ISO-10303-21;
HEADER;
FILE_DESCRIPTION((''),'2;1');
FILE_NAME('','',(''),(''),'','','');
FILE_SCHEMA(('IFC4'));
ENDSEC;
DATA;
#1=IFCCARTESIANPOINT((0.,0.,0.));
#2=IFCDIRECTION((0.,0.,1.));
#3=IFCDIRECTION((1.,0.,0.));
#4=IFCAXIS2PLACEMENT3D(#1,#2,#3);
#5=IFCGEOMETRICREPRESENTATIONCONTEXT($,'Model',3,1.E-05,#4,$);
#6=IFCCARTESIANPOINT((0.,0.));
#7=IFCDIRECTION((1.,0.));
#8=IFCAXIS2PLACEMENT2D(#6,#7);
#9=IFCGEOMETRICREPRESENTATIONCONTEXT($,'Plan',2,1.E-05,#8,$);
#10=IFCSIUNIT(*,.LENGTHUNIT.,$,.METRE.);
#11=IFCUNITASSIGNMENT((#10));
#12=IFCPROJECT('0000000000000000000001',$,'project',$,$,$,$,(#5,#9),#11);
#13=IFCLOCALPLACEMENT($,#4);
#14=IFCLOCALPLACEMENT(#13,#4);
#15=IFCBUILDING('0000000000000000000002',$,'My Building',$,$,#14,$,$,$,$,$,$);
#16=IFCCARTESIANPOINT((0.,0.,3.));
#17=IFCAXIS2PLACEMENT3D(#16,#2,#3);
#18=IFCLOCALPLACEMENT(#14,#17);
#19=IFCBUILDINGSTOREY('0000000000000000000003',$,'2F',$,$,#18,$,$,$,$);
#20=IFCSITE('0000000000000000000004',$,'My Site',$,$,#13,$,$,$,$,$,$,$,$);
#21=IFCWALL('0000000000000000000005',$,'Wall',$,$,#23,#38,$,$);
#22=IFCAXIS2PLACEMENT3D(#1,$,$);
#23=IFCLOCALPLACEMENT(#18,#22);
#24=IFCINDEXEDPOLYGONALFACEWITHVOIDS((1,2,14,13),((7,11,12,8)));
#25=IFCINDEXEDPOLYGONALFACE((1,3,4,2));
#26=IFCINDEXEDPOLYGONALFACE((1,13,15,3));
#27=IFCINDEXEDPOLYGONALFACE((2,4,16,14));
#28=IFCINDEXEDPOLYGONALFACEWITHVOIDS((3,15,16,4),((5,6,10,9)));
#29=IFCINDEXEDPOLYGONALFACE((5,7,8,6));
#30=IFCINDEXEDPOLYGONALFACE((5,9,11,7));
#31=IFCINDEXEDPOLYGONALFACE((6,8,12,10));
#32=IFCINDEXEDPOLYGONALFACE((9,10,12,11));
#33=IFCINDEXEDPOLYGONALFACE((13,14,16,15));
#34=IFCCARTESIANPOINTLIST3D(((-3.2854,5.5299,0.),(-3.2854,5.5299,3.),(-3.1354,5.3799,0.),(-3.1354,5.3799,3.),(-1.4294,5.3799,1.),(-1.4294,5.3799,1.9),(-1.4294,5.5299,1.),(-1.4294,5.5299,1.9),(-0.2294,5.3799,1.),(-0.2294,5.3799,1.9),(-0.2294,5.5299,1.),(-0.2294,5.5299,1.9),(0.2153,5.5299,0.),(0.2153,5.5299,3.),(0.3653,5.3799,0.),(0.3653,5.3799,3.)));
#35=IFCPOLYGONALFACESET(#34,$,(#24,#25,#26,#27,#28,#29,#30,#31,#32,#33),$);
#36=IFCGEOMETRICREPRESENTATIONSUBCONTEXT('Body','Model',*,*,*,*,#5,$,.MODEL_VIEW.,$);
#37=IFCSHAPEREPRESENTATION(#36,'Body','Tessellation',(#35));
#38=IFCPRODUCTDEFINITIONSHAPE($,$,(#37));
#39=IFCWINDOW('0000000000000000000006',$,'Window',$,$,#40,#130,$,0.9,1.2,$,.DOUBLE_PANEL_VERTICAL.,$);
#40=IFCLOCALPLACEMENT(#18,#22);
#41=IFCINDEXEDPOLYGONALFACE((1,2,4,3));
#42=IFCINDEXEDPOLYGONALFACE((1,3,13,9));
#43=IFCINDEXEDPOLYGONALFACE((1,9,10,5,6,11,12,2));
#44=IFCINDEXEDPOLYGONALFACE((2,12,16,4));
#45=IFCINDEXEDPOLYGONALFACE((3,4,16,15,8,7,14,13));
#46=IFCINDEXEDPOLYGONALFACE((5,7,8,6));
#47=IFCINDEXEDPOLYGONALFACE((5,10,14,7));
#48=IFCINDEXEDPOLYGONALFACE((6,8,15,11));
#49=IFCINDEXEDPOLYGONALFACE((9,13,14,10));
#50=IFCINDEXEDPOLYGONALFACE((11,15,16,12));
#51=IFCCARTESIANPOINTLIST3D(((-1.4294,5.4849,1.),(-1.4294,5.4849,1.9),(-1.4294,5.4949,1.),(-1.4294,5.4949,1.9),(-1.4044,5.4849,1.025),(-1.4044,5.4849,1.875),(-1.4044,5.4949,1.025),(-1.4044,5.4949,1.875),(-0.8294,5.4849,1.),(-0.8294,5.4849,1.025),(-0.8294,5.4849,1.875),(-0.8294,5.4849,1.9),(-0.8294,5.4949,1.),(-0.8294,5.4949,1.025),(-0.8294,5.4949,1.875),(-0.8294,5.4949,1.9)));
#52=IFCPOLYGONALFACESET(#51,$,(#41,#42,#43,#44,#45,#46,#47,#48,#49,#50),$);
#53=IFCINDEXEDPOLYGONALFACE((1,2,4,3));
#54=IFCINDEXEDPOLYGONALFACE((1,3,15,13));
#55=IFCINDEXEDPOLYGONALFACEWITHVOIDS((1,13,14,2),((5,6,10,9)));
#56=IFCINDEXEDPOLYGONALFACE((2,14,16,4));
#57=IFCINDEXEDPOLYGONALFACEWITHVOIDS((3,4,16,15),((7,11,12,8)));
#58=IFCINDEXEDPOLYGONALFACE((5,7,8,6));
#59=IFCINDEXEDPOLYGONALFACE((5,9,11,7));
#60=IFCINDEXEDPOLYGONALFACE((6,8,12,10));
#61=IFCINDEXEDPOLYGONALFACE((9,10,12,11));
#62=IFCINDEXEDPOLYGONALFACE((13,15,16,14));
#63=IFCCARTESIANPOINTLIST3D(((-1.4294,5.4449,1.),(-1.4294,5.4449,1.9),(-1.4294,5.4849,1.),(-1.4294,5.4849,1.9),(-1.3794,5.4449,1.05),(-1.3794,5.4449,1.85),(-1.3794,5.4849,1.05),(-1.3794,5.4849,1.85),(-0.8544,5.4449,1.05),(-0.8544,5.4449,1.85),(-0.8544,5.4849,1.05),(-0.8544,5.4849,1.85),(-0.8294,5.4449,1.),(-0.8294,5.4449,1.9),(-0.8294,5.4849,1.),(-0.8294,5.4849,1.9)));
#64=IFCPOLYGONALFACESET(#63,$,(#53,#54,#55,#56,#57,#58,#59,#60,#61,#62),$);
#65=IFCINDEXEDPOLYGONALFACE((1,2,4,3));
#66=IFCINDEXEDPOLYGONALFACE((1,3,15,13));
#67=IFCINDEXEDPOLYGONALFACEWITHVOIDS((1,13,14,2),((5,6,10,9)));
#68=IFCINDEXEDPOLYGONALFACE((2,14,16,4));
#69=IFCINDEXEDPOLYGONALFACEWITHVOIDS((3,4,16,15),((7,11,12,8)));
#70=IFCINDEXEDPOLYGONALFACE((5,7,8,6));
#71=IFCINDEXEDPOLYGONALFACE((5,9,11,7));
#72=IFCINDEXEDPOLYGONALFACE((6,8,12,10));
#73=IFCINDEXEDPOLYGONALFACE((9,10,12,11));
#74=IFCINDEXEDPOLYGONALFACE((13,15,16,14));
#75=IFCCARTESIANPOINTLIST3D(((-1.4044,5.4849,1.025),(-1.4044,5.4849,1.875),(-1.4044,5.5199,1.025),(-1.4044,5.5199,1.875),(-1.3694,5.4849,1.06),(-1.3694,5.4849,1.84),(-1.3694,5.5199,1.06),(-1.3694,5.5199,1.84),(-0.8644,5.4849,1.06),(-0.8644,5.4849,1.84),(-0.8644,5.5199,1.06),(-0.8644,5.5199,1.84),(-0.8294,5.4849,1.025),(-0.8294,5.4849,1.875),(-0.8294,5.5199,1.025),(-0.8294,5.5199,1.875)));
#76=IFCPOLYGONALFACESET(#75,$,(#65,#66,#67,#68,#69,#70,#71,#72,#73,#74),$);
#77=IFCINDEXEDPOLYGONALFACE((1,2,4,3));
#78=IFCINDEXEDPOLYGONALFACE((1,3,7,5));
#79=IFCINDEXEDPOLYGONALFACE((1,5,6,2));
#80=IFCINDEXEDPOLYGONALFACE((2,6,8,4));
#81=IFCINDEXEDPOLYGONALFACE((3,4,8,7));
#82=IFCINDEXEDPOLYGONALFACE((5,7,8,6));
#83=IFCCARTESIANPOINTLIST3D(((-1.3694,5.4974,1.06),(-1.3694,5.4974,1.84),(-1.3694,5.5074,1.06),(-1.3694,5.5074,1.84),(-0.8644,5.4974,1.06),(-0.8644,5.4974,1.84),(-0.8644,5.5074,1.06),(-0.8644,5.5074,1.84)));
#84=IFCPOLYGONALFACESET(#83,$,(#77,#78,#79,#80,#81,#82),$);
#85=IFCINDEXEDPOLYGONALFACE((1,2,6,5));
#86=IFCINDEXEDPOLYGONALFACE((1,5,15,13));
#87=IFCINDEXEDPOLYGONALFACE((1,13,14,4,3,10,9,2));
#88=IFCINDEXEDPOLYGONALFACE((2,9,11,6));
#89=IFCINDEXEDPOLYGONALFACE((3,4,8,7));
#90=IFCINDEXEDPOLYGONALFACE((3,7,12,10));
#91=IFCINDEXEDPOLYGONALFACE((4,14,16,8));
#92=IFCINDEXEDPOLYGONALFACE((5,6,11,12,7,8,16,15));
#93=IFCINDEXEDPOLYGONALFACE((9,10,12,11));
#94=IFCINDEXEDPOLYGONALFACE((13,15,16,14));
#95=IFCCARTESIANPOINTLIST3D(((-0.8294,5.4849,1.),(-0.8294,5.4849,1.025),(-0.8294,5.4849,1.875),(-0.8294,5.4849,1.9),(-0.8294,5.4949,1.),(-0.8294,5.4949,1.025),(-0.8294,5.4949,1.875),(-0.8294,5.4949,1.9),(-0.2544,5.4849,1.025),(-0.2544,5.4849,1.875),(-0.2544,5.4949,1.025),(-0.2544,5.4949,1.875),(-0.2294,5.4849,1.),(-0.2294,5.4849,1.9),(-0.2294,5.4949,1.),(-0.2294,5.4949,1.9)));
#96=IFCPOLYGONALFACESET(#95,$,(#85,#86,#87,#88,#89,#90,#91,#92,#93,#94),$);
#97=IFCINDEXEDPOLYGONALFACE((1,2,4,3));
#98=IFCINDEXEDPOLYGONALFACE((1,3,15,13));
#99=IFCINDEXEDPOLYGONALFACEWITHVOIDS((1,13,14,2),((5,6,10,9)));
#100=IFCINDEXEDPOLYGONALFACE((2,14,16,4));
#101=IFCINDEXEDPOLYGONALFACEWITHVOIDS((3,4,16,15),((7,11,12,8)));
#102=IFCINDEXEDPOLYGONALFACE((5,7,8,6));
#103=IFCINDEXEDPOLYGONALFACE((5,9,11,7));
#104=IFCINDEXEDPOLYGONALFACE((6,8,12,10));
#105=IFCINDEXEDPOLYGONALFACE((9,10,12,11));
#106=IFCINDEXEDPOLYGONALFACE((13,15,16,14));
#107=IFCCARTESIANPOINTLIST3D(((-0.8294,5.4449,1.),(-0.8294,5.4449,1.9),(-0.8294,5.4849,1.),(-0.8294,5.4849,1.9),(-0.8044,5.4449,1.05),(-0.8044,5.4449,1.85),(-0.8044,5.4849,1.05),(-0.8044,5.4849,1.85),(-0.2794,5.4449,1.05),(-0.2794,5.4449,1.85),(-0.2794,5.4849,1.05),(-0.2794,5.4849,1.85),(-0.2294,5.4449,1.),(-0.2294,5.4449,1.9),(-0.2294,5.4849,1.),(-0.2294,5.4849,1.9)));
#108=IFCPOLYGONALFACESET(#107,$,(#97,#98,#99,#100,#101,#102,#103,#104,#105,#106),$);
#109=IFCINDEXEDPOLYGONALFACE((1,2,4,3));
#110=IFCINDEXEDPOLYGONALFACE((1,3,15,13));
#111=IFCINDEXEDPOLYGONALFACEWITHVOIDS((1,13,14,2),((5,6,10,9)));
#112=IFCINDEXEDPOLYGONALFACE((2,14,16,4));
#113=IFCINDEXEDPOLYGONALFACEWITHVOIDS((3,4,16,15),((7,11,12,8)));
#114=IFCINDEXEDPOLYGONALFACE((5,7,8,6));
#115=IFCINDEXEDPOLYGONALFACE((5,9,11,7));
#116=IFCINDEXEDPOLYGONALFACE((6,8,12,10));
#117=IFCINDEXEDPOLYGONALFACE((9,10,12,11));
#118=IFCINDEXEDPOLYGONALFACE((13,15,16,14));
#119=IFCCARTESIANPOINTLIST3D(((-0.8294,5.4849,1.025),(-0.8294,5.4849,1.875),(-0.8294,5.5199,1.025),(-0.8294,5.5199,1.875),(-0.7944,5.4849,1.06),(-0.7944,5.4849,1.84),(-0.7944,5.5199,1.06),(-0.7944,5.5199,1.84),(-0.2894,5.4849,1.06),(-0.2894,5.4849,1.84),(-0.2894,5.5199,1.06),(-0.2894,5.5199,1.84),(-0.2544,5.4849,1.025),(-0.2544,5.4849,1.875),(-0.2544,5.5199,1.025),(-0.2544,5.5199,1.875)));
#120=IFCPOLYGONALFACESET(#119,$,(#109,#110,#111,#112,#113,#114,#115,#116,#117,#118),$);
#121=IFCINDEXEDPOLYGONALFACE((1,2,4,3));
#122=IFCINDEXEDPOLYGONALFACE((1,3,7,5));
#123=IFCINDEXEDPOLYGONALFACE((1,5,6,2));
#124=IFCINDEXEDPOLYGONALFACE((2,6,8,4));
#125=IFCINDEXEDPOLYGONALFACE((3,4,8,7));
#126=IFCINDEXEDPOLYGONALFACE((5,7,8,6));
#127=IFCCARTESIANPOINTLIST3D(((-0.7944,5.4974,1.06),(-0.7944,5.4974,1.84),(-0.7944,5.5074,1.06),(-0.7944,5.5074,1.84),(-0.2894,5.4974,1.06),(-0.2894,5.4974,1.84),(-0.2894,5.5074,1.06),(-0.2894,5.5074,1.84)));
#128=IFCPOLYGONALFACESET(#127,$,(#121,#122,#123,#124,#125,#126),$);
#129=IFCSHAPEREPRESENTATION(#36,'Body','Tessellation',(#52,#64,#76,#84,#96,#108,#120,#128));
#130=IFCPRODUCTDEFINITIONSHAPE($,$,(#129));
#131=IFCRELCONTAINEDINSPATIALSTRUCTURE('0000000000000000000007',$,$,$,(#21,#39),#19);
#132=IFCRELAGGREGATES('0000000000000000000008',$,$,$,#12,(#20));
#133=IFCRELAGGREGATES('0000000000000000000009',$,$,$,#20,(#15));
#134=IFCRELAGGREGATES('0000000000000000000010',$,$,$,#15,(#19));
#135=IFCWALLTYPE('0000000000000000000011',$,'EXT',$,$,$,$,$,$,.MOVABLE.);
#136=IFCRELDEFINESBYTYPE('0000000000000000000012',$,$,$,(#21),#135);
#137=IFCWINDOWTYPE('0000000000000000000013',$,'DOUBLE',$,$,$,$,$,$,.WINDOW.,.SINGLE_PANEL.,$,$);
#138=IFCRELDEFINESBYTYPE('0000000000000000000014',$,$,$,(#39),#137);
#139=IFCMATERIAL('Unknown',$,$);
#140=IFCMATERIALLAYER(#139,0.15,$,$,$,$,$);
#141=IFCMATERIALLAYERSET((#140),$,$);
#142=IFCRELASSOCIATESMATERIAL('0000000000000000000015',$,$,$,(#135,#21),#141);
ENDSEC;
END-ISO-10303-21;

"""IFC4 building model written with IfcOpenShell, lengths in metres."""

from ifc_helpers import new_model, entity, si_unit, frame, origin_with_axes, origin_2d_with_axis, place, context, subcontext, project, spatial, line, indexed_curve, outline, extrude, shape, source, transform, mapped, material, layer, layer_set, layer_usage, type_object, type_shapes, element, fill, save


model = new_model("IFC4")

# Units and contexts
model_context = context("Model", 3, precision=1e-05, world=origin_with_axes())
plan_context = context("Plan", 2, precision=1e-05, world=origin_2d_with_axis())
body_context_1 = subcontext(model_context, "Body", "Model", "MODEL_VIEW")
body_context_2 = subcontext(plan_context, "Body", "Plan", "PLAN_VIEW")
ifc_project = project(units=[si_unit("LENGTHUNIT", "METRE")], contexts=[model_context, plan_context])

# Site, building, storey
site_placement = place(None, origin_with_axes())
site = spatial("IfcSite", under=ifc_project, at=site_placement, Name="My Site")
building_placement = place(site_placement, origin_with_axes())
building = spatial("IfcBuilding", under=site, at=building_placement, Name="My Building")
storey_placement = place(building_placement, frame((0.0, 0.0, 3.0), z_axis=(0.0, 0.0, 1.0), x_axis=(1.0, 0.0, 0.0)))
storey = spatial("IfcBuildingStorey", under=building, at=storey_placement, Name="2F")

# Shared definitions
ifc_material = material(Name="Unknown")

# Shared definitions
ifc_layer_1 = layer(ifc_material, 0.15)
ifc_layer_set_1 = layer_set([ifc_layer_1])
wall_type_1 = type_object("IfcWallType", Name="EXT", PredefinedType="MOVABLE", material=ifc_layer_set_1)

# Wall, opening, window
ifc_layer_usage_1 = layer_usage(ifc_layer_set_1, "AXIS2", "POSITIVE", -0.15)
wall_1_placement = place(storey_placement, frame((-3.2854, 5.5299, 0.0), z_axis=(0.0, 0.0, 1.0), x_axis=(1.0, 0.0, 0.0)))
wall_1 = element("IfcWall", 1, at=wall_1_placement, inside=storey, type_object=wall_type_1, material=ifc_layer_usage_1, Name="Wall", context=body_context_1, shape_type="SweptSolid", body=[
    extrude(outline(indexed_curve([(0.15, -0.15), (0.0, 0.0), (3.5007, 0.0), (3.6507, -0.15)], segments=[line(1, 2, 3, 4, 1)])), origin_with_axes(), (0.0, 0.0, 1.0), 3.0),
])
placement_1 = place(storey_placement, frame((-1.4294, 5.3949, 1.0), z_axis=(0.0, 0.0, 1.0), x_axis=(1.0, 0.0, 0.0)))
opening_1 = element("IfcOpeningElement", 2, at=placement_1, cuts=wall_1, PredefinedType="OPENING", context=body_context_1, shape_type="SweptSolid", body=[
    extrude(outline(indexed_curve([(0.0, 0.0), (1.2, 0.0), (1.2, 0.9), (0.0, 0.9)], segments=[line(1, 2, 3, 4, 1)])), frame((0.0, -0.6, 0.0), z_axis=(0.0, -1.0, 0.0), x_axis=(1.0, 0.0, 0.0)), (0.0, 0.0, -1.0), 1.2),
])
window_type_1 = type_object("IfcWindowType", Name="DOUBLE", PartitioningType="SINGLE_PANEL", PredefinedType="WINDOW")
shared_shape_1 = source(origin_with_axes(), body_context_1, "Body", "SweptSolid", [
    extrude(outline(indexed_curve([(0.6, 0.0), (0.0, 0.0), (0.0, 0.9), (0.6, 0.9), (0.6, 0.875), (0.025, 0.875), (0.025, 0.025), (0.6, 0.025)], segments=[line(1, 2, 3, 4, 5, 6, 7, 8, 1)])), frame((0.0, 0.09, 0.0), z_axis=(0.0, -1.0, 0.0), x_axis=(1.0, 0.0, 0.0)), (0.0, 0.0, -1.0), 0.01),
    extrude(outline(indexed_curve([(0.0, 0.0), (0.6, 0.0), (0.6, 0.9), (0.0, 0.9)], segments=[line(1, 2, 3, 4, 1)]), holes=[indexed_curve([(0.05, 0.05), (0.575, 0.05), (0.575, 0.85), (0.05, 0.85)], segments=[line(1, 2, 3, 4, 1)])]), frame((0.0, 0.05, 0.0), z_axis=(0.0, -1.0, 0.0), x_axis=(1.0, 0.0, 0.0)), (0.0, 0.0, -1.0), 0.04),
    extrude(outline(indexed_curve([(0.0, 0.0), (0.575, 0.0), (0.575, 0.85), (0.0, 0.85)], segments=[line(1, 2, 3, 4, 1)]), holes=[indexed_curve([(0.035, 0.035), (0.54, 0.035), (0.54, 0.815), (0.035, 0.815)], segments=[line(1, 2, 3, 4, 1)])]), frame((0.025, 0.09, 0.025), z_axis=(0.0, -1.0, 0.0), x_axis=(1.0, 0.0, 0.0)), (0.0, 0.0, -1.0), 0.035),
    extrude(outline(indexed_curve([(0.035, 0.035), (0.54, 0.035), (0.54, 0.815), (0.035, 0.815)], segments=[line(1, 2, 3, 4, 1)])), frame((0.025, 0.1025, 0.025), z_axis=(0.0, -1.0, 0.0), x_axis=(1.0, 0.0, 0.0)), (0.0, 0.0, -1.0), 0.01),
    extrude(outline(indexed_curve([(0.0, 0.9), (0.6, 0.9), (0.6, 0.0), (0.0, 0.0), (0.0, 0.025), (0.575, 0.025), (0.575, 0.875), (0.0, 0.875)], segments=[line(1, 2, 3, 4, 5, 6, 7, 8, 1)])), frame((0.6, 0.09, 0.0), z_axis=(0.0, -1.0, 0.0), x_axis=(1.0, 0.0, 0.0)), (0.0, 0.0, -1.0), 0.01),
    extrude(outline(indexed_curve([(0.0, 0.0), (0.6, 0.0), (0.6, 0.9), (0.0, 0.9)], segments=[line(1, 2, 3, 4, 1)]), holes=[indexed_curve([(0.025, 0.05), (0.55, 0.05), (0.55, 0.85), (0.025, 0.85)], segments=[line(1, 2, 3, 4, 1)])]), frame((0.6, 0.05, 0.0), z_axis=(0.0, -1.0, 0.0), x_axis=(1.0, 0.0, 0.0)), (0.0, 0.0, -1.0), 0.04),
    extrude(outline(indexed_curve([(0.0, 0.0), (0.575, 0.0), (0.575, 0.85), (0.0, 0.85)], segments=[line(1, 2, 3, 4, 1)]), holes=[indexed_curve([(0.035, 0.035), (0.54, 0.035), (0.54, 0.815), (0.035, 0.815)], segments=[line(1, 2, 3, 4, 1)])]), frame((0.6, 0.09, 0.025), z_axis=(0.0, -1.0, 0.0), x_axis=(1.0, 0.0, 0.0)), (0.0, 0.0, -1.0), 0.035),
    extrude(outline(indexed_curve([(0.035, 0.815), (0.54, 0.815), (0.54, 0.035), (0.035, 0.035), (0.035, 0.815)])), frame((0.6, 0.1025, 0.025), z_axis=(0.0, -1.0, 0.0), x_axis=(1.0, 0.0, 0.0)), (0.0, 0.0, -1.0), 0.01),
])
shared_shape_2 = source(origin_with_axes(), body_context_2, "Body", "Curve2D", [
    entity("IfcIndexedPolyCurve", entity("IfcCartesianPointList2D", [[0.05, 0.05], [0.575, 0.05]])),
    entity("IfcIndexedPolyCurve", entity("IfcCartesianPointList2D", [[0.0, 0.1], [0.025, 0.1], [0.025, 0.09], [0.05, 0.09], [0.05, 0.05], [0.0, 0.05]]), [entity("IfcLineIndex", [1, 2, 3, 4, 5, 6, 1])]),
    entity("IfcIndexedPolyCurve", entity("IfcCartesianPointList2D", [[0.6, 0.1], [0.6, 0.1], [0.6, 0.09], [0.575, 0.09], [0.575, 0.05], [0.6, 0.05]])),
    entity("IfcIndexedPolyCurve", entity("IfcCartesianPointList2D", [[0.025, 0.09], [0.06, 0.09], [0.06, 0.125], [0.025, 0.125]]), [entity("IfcLineIndex", [1, 2, 3, 4, 1])]),
    entity("IfcIndexedPolyCurve", entity("IfcCartesianPointList2D", [[0.6, 0.09], [0.565, 0.09], [0.565, 0.125], [0.6, 0.125]]), [entity("IfcLineIndex", [1, 2, 3, 4, 1])]),
    entity("IfcIndexedPolyCurve", entity("IfcCartesianPointList2D", [[0.06, 0.09], [0.565, 0.09]])),
    entity("IfcIndexedPolyCurve", entity("IfcCartesianPointList2D", [[0.06, 0.125], [0.565, 0.125]])),
    entity("IfcIndexedPolyCurve", entity("IfcCartesianPointList2D", [[0.06, 0.1075], [0.565, 0.1075]])),
    entity("IfcIndexedPolyCurve", entity("IfcCartesianPointList2D", [[0.625, 0.05], [1.15, 0.05]])),
    entity("IfcIndexedPolyCurve", entity("IfcCartesianPointList2D", [[0.6, 0.1], [0.6, 0.1], [0.6, 0.09], [0.625, 0.09], [0.625, 0.05], [0.6, 0.05]])),
    entity("IfcIndexedPolyCurve", entity("IfcCartesianPointList2D", [[1.2, 0.1], [1.175, 0.1], [1.175, 0.09], [1.15, 0.09], [1.15, 0.05], [1.2, 0.05]]), [entity("IfcLineIndex", [1, 2, 3, 4, 5, 6, 1])]),
    entity("IfcIndexedPolyCurve", entity("IfcCartesianPointList2D", [[0.6, 0.09], [0.635, 0.09], [0.635, 0.125], [0.6, 0.125]]), [entity("IfcLineIndex", [1, 2, 3, 4, 1])]),
    entity("IfcIndexedPolyCurve", entity("IfcCartesianPointList2D", [[1.175, 0.09], [1.14, 0.09], [1.14, 0.125], [1.175, 0.125]]), [entity("IfcLineIndex", [1, 2, 3, 4, 1])]),
    entity("IfcIndexedPolyCurve", entity("IfcCartesianPointList2D", [[0.635, 0.09], [1.14, 0.09]])),
    entity("IfcIndexedPolyCurve", entity("IfcCartesianPointList2D", [[0.635, 0.125], [1.14, 0.125]])),
    entity("IfcIndexedPolyCurve", entity("IfcCartesianPointList2D", [[0.635, 0.1075], [1.14, 0.1075]])),
])
type_shapes(window_type_1, [shared_shape_1, shared_shape_2])
window_1 = element("IfcWindow", 3, at=placement_1, inside=storey, type_object=window_type_1, Name="Window", OverallHeight=0.9, OverallWidth=1.2, PartitioningType="DOUBLE_PANEL_VERTICAL", shapes=[
    shape(body_context_1, "Body", "MappedRepresentation", [mapped(shared_shape_1, transform((0.0, 0.0, 0.0), x_axis=(1.0, 0.0, 0.0), y_axis=(0.0, 1.0, 0.0), z_axis=(0.0, 0.0, 1.0), scale=1.0))]),
    shape(body_context_2, "Body", "MappedRepresentation", [mapped(shared_shape_2, transform((0.0, 0.0, 0.0), x_axis=(1.0, 0.0, 0.0), y_axis=(0.0, 1.0, 0.0), z_axis=(0.0, 0.0, 1.0), scale=1.0))]),
])
fill(opening_1, window_1)

save(model, "model.ifc")
